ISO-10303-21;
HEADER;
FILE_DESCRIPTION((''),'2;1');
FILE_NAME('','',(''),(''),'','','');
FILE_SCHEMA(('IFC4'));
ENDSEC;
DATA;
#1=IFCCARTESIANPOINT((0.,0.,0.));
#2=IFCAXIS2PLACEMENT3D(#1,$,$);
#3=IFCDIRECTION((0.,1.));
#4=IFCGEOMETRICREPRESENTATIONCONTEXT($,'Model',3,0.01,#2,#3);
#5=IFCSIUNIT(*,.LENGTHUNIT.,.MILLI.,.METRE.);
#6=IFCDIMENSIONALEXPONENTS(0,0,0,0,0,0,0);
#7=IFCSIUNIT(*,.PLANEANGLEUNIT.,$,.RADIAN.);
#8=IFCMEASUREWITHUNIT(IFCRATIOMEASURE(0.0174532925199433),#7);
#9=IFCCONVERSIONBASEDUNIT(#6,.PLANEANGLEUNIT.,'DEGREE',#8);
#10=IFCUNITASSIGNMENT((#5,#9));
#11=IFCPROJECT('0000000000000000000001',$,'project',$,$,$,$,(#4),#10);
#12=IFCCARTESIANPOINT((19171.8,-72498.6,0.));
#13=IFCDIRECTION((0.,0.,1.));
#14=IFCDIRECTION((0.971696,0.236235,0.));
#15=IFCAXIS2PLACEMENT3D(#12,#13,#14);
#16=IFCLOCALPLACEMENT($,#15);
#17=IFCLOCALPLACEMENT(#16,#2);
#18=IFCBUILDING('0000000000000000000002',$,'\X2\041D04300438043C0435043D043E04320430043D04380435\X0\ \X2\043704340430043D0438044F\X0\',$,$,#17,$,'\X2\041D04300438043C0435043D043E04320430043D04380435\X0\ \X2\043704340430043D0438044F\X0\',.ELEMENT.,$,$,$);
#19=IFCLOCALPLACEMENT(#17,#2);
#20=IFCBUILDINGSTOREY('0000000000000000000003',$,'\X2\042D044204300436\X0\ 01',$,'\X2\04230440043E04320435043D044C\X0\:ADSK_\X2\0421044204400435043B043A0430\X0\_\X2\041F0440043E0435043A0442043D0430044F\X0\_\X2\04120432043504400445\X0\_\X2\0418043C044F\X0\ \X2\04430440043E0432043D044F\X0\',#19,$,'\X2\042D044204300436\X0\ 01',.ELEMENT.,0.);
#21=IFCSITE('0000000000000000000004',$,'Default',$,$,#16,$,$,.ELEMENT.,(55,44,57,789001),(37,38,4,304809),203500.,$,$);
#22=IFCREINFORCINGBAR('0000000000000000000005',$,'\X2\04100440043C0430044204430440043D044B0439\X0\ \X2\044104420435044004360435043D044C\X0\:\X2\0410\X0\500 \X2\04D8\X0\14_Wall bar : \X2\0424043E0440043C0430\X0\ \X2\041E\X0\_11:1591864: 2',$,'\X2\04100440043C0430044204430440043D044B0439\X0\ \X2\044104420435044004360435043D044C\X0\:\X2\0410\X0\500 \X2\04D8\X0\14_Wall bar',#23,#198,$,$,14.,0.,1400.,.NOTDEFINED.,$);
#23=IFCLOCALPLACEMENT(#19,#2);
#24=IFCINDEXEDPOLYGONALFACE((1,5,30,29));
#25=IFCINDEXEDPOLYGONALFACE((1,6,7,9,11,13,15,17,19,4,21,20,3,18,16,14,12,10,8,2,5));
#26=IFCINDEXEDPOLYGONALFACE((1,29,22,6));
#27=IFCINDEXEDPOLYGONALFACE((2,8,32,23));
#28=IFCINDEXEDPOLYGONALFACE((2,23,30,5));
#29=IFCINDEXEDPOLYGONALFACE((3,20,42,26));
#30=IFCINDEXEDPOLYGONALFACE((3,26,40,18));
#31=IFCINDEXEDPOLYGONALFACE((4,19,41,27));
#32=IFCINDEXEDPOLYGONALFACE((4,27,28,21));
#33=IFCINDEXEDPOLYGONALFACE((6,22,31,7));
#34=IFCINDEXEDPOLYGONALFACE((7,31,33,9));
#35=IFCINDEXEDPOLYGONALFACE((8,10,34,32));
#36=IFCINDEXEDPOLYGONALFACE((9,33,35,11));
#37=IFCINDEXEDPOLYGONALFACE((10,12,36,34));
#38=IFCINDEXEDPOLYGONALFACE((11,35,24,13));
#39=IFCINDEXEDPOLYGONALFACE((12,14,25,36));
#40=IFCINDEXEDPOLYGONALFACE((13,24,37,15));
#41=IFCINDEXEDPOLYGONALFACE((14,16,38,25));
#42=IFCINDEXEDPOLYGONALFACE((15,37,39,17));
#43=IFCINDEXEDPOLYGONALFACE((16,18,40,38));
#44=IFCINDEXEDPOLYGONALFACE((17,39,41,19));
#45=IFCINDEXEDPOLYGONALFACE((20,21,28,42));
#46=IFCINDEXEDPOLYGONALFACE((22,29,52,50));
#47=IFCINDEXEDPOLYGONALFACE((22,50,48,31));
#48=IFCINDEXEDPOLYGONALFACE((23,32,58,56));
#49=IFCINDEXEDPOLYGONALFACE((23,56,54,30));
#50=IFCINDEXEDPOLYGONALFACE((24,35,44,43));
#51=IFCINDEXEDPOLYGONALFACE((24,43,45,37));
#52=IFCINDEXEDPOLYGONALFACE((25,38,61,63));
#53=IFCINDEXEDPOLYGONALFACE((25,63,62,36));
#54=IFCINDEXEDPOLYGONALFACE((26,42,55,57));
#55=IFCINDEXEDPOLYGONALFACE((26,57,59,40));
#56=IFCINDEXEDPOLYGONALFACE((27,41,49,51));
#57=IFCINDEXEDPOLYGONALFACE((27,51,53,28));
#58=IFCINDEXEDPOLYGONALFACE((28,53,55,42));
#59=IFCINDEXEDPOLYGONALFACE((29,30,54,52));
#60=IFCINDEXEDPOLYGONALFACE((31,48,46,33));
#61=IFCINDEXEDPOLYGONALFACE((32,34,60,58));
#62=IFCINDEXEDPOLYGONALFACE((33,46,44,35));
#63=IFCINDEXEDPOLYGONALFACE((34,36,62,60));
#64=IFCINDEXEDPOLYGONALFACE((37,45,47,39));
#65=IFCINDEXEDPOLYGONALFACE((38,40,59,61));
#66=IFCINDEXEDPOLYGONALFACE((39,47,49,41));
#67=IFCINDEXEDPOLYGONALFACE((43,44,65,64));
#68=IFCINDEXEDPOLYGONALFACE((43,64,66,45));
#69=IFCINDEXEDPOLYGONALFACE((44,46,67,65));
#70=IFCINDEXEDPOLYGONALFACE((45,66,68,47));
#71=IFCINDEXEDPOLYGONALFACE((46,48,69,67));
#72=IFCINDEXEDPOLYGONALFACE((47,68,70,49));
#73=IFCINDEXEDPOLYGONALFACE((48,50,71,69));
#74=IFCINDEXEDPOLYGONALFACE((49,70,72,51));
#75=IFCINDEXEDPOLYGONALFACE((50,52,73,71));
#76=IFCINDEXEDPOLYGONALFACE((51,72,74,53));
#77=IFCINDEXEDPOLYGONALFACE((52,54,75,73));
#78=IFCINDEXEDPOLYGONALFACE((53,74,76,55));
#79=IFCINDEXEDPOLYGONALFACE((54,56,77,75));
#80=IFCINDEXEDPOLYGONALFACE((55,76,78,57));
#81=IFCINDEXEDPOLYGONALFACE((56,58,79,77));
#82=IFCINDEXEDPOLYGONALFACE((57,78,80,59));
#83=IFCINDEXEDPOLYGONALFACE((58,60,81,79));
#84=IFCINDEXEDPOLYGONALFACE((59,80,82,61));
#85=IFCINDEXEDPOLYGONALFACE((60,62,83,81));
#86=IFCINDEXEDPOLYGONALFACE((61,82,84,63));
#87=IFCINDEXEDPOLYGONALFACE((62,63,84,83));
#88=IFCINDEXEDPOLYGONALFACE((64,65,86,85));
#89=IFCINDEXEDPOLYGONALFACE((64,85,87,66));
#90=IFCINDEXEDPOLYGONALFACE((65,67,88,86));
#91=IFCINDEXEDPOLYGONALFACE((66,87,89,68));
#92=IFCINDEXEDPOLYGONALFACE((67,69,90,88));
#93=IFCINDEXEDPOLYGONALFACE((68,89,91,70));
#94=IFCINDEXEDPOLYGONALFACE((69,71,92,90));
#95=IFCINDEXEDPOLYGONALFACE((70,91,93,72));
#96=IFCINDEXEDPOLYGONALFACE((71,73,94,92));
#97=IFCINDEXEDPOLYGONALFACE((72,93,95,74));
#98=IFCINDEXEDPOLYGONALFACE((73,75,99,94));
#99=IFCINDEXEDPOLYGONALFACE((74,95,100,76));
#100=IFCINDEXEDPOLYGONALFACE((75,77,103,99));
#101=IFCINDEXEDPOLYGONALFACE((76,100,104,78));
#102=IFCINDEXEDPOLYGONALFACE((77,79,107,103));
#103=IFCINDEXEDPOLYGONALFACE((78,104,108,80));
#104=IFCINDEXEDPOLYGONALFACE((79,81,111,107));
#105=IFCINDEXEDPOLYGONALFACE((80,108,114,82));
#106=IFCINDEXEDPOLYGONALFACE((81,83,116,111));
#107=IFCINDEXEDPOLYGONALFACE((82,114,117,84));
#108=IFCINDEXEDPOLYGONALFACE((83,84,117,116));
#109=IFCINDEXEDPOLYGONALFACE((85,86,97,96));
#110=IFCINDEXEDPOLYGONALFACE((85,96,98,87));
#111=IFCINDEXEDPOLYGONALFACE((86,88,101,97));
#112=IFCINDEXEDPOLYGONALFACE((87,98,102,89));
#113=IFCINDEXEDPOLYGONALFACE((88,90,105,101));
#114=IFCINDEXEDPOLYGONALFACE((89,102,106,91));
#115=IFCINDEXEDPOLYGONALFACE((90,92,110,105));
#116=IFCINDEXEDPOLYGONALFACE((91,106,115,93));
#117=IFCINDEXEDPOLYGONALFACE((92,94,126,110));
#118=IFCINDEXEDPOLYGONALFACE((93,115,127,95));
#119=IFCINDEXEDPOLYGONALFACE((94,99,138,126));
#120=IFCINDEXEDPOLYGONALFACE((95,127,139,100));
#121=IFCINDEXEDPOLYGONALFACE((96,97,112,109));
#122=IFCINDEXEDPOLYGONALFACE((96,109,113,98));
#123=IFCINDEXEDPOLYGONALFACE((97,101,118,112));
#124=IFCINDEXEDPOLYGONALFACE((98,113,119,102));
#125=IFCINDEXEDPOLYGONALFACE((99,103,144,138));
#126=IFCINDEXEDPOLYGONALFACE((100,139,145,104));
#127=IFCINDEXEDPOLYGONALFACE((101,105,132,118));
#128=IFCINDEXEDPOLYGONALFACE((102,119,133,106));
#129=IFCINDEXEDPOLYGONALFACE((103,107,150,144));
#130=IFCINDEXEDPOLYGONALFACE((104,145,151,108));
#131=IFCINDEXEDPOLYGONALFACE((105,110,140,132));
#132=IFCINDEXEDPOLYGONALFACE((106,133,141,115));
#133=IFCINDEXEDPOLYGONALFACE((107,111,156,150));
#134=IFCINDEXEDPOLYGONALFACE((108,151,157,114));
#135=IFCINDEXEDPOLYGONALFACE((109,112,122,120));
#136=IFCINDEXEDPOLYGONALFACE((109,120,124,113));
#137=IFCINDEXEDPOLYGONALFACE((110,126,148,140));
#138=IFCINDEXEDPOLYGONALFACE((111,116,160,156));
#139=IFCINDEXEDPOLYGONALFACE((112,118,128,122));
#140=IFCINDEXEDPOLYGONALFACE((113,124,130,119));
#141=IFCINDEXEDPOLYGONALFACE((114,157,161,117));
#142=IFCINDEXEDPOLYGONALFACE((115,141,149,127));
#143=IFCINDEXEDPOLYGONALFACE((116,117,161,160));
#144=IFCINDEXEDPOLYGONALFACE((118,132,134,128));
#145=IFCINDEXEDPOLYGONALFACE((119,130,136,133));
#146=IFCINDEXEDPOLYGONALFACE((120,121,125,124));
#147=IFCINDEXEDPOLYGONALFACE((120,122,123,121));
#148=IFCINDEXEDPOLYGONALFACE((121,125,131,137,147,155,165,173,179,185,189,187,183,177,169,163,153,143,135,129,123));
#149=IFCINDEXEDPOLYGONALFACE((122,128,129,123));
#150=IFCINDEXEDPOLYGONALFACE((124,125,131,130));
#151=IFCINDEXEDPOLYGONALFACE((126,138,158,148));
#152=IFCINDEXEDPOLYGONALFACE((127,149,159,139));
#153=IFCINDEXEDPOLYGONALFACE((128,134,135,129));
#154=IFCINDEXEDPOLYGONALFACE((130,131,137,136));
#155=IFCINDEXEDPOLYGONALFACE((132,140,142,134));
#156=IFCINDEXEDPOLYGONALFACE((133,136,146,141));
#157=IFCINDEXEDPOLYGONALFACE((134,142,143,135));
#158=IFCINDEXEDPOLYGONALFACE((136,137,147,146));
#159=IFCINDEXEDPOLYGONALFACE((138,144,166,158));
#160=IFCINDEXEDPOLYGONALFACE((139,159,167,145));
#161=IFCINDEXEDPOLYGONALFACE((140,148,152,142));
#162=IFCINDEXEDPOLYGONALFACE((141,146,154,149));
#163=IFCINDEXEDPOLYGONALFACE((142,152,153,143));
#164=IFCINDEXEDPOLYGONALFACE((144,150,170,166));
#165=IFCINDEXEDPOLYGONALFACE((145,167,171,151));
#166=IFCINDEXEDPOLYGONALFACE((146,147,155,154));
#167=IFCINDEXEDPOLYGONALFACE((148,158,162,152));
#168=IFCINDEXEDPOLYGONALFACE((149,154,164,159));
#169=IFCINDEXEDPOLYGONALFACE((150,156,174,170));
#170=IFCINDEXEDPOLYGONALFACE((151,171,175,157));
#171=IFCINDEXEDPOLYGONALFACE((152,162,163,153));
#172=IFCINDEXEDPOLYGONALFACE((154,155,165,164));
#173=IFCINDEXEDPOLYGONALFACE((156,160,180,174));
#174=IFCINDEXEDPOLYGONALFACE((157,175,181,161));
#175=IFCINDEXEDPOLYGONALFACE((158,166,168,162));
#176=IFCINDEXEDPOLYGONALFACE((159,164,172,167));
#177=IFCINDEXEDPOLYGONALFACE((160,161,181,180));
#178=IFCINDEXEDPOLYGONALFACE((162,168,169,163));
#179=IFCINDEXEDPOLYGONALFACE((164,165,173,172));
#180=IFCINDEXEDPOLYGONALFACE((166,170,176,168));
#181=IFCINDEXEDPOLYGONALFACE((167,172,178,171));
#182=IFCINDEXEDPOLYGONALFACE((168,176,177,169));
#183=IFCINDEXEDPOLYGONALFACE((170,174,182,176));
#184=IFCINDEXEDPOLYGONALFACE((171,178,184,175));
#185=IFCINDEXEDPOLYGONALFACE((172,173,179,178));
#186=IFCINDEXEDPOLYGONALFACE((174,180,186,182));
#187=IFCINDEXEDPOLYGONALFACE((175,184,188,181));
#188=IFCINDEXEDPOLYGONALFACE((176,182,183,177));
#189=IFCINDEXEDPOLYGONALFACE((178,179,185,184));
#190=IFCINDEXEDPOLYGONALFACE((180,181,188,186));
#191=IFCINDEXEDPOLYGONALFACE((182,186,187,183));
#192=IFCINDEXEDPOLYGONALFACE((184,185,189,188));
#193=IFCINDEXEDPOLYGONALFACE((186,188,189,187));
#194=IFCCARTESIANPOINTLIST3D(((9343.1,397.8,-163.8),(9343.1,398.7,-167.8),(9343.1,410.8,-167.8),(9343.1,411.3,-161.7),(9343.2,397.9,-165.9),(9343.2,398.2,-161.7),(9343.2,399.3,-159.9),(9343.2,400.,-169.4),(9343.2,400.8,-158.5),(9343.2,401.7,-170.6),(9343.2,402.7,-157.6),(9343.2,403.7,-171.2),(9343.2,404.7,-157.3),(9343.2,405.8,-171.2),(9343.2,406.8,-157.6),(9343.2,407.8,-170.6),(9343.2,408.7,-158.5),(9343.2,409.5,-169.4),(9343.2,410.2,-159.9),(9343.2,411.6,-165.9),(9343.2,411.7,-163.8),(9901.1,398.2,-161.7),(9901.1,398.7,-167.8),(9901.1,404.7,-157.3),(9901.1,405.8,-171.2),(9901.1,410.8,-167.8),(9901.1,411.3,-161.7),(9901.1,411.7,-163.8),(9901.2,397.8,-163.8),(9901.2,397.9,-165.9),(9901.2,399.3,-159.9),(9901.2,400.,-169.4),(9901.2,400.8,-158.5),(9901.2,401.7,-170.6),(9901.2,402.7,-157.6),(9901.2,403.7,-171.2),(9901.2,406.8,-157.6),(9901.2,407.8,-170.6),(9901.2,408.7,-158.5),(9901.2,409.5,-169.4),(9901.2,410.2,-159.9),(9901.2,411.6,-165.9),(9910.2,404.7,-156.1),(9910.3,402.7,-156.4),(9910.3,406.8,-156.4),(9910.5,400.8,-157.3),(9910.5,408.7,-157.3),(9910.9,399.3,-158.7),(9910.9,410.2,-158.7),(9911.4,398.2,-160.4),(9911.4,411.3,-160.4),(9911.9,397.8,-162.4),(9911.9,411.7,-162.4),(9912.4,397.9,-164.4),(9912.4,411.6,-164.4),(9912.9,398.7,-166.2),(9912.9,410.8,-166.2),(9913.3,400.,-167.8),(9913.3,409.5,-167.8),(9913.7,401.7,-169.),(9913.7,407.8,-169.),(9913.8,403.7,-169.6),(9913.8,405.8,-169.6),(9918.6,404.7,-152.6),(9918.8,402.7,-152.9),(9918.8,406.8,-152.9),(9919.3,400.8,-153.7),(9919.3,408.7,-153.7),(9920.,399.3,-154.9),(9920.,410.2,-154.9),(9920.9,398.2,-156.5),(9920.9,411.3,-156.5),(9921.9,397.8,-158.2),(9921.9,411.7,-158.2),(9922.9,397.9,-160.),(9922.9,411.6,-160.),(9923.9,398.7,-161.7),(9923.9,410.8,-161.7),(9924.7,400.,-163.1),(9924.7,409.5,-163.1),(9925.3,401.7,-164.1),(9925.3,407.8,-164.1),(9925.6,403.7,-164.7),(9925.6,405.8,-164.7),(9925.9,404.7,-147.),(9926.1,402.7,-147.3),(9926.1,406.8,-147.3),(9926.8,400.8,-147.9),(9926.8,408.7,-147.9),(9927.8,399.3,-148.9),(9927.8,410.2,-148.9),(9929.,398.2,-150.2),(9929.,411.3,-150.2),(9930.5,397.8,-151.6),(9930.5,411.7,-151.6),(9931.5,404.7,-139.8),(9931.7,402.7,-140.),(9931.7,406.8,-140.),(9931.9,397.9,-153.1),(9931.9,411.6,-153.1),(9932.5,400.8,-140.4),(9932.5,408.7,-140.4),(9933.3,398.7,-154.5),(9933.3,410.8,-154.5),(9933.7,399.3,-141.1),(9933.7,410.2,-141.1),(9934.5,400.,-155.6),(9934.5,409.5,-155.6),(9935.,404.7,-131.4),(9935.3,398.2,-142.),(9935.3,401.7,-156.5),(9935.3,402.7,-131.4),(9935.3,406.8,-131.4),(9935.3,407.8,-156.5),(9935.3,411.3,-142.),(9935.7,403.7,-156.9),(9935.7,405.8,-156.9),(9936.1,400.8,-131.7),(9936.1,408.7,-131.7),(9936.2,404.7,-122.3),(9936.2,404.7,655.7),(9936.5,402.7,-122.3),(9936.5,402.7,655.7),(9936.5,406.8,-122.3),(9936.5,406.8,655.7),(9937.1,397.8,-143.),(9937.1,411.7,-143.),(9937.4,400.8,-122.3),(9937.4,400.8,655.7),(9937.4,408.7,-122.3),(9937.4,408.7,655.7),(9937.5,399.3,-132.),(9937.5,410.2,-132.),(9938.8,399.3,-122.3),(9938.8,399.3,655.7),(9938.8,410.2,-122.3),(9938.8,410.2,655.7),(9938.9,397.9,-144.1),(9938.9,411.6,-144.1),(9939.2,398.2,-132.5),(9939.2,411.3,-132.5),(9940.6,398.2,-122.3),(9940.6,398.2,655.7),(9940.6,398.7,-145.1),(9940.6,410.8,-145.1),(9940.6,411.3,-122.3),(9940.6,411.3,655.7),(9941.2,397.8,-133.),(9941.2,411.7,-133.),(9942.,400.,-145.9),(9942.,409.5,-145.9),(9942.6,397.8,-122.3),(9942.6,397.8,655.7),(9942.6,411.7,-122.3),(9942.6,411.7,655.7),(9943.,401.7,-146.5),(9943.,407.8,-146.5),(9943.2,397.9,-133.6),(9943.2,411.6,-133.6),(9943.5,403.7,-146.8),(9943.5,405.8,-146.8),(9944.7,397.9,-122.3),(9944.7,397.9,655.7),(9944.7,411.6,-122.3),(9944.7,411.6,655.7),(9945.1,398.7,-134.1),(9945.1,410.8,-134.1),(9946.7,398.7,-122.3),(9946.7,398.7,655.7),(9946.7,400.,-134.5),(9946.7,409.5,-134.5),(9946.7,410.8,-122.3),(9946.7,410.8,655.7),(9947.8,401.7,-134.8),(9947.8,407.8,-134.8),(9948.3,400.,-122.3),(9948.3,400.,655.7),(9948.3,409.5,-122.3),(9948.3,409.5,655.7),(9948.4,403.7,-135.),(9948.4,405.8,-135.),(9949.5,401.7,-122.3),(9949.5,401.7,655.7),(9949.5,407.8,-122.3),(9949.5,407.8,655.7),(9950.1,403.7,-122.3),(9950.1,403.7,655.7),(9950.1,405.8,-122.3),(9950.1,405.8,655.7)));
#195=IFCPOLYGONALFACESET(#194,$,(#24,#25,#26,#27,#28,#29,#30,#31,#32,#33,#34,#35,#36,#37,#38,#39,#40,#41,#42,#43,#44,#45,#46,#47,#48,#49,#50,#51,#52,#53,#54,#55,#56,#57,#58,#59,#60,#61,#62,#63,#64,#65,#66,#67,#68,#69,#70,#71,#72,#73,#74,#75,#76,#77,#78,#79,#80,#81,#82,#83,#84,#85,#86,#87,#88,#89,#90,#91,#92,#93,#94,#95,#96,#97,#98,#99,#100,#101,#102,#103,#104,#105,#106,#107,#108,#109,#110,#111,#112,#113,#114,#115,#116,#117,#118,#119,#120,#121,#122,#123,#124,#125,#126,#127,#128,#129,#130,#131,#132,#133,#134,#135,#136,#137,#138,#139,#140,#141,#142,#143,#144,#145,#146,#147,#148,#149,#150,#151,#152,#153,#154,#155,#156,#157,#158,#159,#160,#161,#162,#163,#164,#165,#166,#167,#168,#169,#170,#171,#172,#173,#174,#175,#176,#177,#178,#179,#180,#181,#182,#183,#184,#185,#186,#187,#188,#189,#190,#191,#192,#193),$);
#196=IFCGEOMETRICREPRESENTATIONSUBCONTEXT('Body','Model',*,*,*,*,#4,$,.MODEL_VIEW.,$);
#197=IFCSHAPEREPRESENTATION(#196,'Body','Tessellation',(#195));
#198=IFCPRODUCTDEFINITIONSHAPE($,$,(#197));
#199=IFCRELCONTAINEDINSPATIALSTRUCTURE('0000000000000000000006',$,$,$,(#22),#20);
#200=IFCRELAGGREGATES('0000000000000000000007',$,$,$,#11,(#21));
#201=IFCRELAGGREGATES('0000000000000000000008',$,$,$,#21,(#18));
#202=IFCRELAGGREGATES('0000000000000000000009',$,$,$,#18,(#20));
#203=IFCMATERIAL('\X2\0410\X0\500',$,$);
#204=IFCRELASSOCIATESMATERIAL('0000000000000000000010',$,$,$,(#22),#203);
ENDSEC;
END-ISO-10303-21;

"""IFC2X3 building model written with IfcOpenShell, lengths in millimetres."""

from ifc_helpers import new_model, entity, si_unit, converted_unit, direction, frame, origin, place, context, subcontext, project, spatial, material, element, save


model = new_model("IFC2X3")

# Units and contexts
model_context = context("Model", 3, precision=0.01, world=origin(), true_north=direction((0.0, 1.0)))
body_context = subcontext(model_context, "Body", "Model", "MODEL_VIEW")
ifc_project = project(units=[si_unit("LENGTHUNIT", "METRE", prefix="MILLI"), converted_unit("PLANEANGLEUNIT", "DEGREE", entity("IfcRatioMeasure", 0.0174532925199433), si_unit("PLANEANGLEUNIT", "RADIAN"), dimensions=[0, 0, 0, 0, 0, 0, 0])], contexts=[model_context])

# Site, building, storey
site_placement = place(None, frame((19171.8, -72498.6, 0.0), z_axis=(0.0, 0.0, 1.0), x_axis=(0.971696, 0.236235, 0.0)))
site = spatial("IfcSite", under=ifc_project, at=site_placement, Name="Default", CompositionType="ELEMENT", RefLatitude=(55, 44, 57, 789001), RefLongitude=(37, 38, 4, 304809), RefElevation=203500.0)
building_placement = place(site_placement, origin())
building = spatial("IfcBuilding", under=site, at=building_placement, Name="Наименование здания", LongName="Наименование здания", CompositionType="ELEMENT")
storey_placement = place(building_placement, origin())
storey = spatial("IfcBuildingStorey", under=building, at=storey_placement, Name="Этаж 01", ObjectType="Уровень:ADSK_Стрелка_Проектная_Вверх_Имя уровня", LongName="Этаж 01", CompositionType="ELEMENT", Elevation=0.0)

# Reinforcing bar
ifc_material = material(Name="А500")
placement = place(storey_placement, origin())
element("IfcReinforcingBar", 1, at=placement, inside=storey, material=ifc_material, Name="Арматурный стержень:А500 Ә14_Wall bar : Форма О_11:1591864: 2", ObjectType="Арматурный стержень:А500 Ә14_Wall bar", BarLength=1400.0, BarRole="NOTDEFINED", CrossSectionArea=0.0, NominalDiameter=14.0, context=body_context, shape_type="AdvancedSweptSolid", body=[
    entity("IfcSweptDiskSolid", entity("IfcCompositeCurve", [entity("IfcCompositeCurveSegment", "CONTINUOUS", True, entity("IfcPolyline", [entity("IfcCartesianPoint", [9943.1, 404.7, 655.7]), entity("IfcCartesianPoint", [9943.1, 404.7, -122.3])])), entity("IfcCompositeCurveSegment", "CONTINUOUS", True, entity("IfcTrimmedCurve", entity("IfcCircle", entity("IfcAxis2Placement3D", entity("IfcCartesianPoint", [9901.1, 404.7, -122.3]), entity("IfcDirection", [0.0, 1.0, 0.0]), entity("IfcDirection", [0.0, 0.0, -1.0])), 42.0), [entity("IfcParameterValue", 270.0)], [entity("IfcParameterValue", 360.0)], True, "PARAMETER")), entity("IfcCompositeCurveSegment", "CONTINUOUS", True, entity("IfcPolyline", [entity("IfcCartesianPoint", [9901.1, 404.7, -164.3]), entity("IfcCartesianPoint", [9343.1, 404.7, -164.3])]))], False), 7.0, None, 0.0, 92.0),
])

save(model, "model.ifc")
